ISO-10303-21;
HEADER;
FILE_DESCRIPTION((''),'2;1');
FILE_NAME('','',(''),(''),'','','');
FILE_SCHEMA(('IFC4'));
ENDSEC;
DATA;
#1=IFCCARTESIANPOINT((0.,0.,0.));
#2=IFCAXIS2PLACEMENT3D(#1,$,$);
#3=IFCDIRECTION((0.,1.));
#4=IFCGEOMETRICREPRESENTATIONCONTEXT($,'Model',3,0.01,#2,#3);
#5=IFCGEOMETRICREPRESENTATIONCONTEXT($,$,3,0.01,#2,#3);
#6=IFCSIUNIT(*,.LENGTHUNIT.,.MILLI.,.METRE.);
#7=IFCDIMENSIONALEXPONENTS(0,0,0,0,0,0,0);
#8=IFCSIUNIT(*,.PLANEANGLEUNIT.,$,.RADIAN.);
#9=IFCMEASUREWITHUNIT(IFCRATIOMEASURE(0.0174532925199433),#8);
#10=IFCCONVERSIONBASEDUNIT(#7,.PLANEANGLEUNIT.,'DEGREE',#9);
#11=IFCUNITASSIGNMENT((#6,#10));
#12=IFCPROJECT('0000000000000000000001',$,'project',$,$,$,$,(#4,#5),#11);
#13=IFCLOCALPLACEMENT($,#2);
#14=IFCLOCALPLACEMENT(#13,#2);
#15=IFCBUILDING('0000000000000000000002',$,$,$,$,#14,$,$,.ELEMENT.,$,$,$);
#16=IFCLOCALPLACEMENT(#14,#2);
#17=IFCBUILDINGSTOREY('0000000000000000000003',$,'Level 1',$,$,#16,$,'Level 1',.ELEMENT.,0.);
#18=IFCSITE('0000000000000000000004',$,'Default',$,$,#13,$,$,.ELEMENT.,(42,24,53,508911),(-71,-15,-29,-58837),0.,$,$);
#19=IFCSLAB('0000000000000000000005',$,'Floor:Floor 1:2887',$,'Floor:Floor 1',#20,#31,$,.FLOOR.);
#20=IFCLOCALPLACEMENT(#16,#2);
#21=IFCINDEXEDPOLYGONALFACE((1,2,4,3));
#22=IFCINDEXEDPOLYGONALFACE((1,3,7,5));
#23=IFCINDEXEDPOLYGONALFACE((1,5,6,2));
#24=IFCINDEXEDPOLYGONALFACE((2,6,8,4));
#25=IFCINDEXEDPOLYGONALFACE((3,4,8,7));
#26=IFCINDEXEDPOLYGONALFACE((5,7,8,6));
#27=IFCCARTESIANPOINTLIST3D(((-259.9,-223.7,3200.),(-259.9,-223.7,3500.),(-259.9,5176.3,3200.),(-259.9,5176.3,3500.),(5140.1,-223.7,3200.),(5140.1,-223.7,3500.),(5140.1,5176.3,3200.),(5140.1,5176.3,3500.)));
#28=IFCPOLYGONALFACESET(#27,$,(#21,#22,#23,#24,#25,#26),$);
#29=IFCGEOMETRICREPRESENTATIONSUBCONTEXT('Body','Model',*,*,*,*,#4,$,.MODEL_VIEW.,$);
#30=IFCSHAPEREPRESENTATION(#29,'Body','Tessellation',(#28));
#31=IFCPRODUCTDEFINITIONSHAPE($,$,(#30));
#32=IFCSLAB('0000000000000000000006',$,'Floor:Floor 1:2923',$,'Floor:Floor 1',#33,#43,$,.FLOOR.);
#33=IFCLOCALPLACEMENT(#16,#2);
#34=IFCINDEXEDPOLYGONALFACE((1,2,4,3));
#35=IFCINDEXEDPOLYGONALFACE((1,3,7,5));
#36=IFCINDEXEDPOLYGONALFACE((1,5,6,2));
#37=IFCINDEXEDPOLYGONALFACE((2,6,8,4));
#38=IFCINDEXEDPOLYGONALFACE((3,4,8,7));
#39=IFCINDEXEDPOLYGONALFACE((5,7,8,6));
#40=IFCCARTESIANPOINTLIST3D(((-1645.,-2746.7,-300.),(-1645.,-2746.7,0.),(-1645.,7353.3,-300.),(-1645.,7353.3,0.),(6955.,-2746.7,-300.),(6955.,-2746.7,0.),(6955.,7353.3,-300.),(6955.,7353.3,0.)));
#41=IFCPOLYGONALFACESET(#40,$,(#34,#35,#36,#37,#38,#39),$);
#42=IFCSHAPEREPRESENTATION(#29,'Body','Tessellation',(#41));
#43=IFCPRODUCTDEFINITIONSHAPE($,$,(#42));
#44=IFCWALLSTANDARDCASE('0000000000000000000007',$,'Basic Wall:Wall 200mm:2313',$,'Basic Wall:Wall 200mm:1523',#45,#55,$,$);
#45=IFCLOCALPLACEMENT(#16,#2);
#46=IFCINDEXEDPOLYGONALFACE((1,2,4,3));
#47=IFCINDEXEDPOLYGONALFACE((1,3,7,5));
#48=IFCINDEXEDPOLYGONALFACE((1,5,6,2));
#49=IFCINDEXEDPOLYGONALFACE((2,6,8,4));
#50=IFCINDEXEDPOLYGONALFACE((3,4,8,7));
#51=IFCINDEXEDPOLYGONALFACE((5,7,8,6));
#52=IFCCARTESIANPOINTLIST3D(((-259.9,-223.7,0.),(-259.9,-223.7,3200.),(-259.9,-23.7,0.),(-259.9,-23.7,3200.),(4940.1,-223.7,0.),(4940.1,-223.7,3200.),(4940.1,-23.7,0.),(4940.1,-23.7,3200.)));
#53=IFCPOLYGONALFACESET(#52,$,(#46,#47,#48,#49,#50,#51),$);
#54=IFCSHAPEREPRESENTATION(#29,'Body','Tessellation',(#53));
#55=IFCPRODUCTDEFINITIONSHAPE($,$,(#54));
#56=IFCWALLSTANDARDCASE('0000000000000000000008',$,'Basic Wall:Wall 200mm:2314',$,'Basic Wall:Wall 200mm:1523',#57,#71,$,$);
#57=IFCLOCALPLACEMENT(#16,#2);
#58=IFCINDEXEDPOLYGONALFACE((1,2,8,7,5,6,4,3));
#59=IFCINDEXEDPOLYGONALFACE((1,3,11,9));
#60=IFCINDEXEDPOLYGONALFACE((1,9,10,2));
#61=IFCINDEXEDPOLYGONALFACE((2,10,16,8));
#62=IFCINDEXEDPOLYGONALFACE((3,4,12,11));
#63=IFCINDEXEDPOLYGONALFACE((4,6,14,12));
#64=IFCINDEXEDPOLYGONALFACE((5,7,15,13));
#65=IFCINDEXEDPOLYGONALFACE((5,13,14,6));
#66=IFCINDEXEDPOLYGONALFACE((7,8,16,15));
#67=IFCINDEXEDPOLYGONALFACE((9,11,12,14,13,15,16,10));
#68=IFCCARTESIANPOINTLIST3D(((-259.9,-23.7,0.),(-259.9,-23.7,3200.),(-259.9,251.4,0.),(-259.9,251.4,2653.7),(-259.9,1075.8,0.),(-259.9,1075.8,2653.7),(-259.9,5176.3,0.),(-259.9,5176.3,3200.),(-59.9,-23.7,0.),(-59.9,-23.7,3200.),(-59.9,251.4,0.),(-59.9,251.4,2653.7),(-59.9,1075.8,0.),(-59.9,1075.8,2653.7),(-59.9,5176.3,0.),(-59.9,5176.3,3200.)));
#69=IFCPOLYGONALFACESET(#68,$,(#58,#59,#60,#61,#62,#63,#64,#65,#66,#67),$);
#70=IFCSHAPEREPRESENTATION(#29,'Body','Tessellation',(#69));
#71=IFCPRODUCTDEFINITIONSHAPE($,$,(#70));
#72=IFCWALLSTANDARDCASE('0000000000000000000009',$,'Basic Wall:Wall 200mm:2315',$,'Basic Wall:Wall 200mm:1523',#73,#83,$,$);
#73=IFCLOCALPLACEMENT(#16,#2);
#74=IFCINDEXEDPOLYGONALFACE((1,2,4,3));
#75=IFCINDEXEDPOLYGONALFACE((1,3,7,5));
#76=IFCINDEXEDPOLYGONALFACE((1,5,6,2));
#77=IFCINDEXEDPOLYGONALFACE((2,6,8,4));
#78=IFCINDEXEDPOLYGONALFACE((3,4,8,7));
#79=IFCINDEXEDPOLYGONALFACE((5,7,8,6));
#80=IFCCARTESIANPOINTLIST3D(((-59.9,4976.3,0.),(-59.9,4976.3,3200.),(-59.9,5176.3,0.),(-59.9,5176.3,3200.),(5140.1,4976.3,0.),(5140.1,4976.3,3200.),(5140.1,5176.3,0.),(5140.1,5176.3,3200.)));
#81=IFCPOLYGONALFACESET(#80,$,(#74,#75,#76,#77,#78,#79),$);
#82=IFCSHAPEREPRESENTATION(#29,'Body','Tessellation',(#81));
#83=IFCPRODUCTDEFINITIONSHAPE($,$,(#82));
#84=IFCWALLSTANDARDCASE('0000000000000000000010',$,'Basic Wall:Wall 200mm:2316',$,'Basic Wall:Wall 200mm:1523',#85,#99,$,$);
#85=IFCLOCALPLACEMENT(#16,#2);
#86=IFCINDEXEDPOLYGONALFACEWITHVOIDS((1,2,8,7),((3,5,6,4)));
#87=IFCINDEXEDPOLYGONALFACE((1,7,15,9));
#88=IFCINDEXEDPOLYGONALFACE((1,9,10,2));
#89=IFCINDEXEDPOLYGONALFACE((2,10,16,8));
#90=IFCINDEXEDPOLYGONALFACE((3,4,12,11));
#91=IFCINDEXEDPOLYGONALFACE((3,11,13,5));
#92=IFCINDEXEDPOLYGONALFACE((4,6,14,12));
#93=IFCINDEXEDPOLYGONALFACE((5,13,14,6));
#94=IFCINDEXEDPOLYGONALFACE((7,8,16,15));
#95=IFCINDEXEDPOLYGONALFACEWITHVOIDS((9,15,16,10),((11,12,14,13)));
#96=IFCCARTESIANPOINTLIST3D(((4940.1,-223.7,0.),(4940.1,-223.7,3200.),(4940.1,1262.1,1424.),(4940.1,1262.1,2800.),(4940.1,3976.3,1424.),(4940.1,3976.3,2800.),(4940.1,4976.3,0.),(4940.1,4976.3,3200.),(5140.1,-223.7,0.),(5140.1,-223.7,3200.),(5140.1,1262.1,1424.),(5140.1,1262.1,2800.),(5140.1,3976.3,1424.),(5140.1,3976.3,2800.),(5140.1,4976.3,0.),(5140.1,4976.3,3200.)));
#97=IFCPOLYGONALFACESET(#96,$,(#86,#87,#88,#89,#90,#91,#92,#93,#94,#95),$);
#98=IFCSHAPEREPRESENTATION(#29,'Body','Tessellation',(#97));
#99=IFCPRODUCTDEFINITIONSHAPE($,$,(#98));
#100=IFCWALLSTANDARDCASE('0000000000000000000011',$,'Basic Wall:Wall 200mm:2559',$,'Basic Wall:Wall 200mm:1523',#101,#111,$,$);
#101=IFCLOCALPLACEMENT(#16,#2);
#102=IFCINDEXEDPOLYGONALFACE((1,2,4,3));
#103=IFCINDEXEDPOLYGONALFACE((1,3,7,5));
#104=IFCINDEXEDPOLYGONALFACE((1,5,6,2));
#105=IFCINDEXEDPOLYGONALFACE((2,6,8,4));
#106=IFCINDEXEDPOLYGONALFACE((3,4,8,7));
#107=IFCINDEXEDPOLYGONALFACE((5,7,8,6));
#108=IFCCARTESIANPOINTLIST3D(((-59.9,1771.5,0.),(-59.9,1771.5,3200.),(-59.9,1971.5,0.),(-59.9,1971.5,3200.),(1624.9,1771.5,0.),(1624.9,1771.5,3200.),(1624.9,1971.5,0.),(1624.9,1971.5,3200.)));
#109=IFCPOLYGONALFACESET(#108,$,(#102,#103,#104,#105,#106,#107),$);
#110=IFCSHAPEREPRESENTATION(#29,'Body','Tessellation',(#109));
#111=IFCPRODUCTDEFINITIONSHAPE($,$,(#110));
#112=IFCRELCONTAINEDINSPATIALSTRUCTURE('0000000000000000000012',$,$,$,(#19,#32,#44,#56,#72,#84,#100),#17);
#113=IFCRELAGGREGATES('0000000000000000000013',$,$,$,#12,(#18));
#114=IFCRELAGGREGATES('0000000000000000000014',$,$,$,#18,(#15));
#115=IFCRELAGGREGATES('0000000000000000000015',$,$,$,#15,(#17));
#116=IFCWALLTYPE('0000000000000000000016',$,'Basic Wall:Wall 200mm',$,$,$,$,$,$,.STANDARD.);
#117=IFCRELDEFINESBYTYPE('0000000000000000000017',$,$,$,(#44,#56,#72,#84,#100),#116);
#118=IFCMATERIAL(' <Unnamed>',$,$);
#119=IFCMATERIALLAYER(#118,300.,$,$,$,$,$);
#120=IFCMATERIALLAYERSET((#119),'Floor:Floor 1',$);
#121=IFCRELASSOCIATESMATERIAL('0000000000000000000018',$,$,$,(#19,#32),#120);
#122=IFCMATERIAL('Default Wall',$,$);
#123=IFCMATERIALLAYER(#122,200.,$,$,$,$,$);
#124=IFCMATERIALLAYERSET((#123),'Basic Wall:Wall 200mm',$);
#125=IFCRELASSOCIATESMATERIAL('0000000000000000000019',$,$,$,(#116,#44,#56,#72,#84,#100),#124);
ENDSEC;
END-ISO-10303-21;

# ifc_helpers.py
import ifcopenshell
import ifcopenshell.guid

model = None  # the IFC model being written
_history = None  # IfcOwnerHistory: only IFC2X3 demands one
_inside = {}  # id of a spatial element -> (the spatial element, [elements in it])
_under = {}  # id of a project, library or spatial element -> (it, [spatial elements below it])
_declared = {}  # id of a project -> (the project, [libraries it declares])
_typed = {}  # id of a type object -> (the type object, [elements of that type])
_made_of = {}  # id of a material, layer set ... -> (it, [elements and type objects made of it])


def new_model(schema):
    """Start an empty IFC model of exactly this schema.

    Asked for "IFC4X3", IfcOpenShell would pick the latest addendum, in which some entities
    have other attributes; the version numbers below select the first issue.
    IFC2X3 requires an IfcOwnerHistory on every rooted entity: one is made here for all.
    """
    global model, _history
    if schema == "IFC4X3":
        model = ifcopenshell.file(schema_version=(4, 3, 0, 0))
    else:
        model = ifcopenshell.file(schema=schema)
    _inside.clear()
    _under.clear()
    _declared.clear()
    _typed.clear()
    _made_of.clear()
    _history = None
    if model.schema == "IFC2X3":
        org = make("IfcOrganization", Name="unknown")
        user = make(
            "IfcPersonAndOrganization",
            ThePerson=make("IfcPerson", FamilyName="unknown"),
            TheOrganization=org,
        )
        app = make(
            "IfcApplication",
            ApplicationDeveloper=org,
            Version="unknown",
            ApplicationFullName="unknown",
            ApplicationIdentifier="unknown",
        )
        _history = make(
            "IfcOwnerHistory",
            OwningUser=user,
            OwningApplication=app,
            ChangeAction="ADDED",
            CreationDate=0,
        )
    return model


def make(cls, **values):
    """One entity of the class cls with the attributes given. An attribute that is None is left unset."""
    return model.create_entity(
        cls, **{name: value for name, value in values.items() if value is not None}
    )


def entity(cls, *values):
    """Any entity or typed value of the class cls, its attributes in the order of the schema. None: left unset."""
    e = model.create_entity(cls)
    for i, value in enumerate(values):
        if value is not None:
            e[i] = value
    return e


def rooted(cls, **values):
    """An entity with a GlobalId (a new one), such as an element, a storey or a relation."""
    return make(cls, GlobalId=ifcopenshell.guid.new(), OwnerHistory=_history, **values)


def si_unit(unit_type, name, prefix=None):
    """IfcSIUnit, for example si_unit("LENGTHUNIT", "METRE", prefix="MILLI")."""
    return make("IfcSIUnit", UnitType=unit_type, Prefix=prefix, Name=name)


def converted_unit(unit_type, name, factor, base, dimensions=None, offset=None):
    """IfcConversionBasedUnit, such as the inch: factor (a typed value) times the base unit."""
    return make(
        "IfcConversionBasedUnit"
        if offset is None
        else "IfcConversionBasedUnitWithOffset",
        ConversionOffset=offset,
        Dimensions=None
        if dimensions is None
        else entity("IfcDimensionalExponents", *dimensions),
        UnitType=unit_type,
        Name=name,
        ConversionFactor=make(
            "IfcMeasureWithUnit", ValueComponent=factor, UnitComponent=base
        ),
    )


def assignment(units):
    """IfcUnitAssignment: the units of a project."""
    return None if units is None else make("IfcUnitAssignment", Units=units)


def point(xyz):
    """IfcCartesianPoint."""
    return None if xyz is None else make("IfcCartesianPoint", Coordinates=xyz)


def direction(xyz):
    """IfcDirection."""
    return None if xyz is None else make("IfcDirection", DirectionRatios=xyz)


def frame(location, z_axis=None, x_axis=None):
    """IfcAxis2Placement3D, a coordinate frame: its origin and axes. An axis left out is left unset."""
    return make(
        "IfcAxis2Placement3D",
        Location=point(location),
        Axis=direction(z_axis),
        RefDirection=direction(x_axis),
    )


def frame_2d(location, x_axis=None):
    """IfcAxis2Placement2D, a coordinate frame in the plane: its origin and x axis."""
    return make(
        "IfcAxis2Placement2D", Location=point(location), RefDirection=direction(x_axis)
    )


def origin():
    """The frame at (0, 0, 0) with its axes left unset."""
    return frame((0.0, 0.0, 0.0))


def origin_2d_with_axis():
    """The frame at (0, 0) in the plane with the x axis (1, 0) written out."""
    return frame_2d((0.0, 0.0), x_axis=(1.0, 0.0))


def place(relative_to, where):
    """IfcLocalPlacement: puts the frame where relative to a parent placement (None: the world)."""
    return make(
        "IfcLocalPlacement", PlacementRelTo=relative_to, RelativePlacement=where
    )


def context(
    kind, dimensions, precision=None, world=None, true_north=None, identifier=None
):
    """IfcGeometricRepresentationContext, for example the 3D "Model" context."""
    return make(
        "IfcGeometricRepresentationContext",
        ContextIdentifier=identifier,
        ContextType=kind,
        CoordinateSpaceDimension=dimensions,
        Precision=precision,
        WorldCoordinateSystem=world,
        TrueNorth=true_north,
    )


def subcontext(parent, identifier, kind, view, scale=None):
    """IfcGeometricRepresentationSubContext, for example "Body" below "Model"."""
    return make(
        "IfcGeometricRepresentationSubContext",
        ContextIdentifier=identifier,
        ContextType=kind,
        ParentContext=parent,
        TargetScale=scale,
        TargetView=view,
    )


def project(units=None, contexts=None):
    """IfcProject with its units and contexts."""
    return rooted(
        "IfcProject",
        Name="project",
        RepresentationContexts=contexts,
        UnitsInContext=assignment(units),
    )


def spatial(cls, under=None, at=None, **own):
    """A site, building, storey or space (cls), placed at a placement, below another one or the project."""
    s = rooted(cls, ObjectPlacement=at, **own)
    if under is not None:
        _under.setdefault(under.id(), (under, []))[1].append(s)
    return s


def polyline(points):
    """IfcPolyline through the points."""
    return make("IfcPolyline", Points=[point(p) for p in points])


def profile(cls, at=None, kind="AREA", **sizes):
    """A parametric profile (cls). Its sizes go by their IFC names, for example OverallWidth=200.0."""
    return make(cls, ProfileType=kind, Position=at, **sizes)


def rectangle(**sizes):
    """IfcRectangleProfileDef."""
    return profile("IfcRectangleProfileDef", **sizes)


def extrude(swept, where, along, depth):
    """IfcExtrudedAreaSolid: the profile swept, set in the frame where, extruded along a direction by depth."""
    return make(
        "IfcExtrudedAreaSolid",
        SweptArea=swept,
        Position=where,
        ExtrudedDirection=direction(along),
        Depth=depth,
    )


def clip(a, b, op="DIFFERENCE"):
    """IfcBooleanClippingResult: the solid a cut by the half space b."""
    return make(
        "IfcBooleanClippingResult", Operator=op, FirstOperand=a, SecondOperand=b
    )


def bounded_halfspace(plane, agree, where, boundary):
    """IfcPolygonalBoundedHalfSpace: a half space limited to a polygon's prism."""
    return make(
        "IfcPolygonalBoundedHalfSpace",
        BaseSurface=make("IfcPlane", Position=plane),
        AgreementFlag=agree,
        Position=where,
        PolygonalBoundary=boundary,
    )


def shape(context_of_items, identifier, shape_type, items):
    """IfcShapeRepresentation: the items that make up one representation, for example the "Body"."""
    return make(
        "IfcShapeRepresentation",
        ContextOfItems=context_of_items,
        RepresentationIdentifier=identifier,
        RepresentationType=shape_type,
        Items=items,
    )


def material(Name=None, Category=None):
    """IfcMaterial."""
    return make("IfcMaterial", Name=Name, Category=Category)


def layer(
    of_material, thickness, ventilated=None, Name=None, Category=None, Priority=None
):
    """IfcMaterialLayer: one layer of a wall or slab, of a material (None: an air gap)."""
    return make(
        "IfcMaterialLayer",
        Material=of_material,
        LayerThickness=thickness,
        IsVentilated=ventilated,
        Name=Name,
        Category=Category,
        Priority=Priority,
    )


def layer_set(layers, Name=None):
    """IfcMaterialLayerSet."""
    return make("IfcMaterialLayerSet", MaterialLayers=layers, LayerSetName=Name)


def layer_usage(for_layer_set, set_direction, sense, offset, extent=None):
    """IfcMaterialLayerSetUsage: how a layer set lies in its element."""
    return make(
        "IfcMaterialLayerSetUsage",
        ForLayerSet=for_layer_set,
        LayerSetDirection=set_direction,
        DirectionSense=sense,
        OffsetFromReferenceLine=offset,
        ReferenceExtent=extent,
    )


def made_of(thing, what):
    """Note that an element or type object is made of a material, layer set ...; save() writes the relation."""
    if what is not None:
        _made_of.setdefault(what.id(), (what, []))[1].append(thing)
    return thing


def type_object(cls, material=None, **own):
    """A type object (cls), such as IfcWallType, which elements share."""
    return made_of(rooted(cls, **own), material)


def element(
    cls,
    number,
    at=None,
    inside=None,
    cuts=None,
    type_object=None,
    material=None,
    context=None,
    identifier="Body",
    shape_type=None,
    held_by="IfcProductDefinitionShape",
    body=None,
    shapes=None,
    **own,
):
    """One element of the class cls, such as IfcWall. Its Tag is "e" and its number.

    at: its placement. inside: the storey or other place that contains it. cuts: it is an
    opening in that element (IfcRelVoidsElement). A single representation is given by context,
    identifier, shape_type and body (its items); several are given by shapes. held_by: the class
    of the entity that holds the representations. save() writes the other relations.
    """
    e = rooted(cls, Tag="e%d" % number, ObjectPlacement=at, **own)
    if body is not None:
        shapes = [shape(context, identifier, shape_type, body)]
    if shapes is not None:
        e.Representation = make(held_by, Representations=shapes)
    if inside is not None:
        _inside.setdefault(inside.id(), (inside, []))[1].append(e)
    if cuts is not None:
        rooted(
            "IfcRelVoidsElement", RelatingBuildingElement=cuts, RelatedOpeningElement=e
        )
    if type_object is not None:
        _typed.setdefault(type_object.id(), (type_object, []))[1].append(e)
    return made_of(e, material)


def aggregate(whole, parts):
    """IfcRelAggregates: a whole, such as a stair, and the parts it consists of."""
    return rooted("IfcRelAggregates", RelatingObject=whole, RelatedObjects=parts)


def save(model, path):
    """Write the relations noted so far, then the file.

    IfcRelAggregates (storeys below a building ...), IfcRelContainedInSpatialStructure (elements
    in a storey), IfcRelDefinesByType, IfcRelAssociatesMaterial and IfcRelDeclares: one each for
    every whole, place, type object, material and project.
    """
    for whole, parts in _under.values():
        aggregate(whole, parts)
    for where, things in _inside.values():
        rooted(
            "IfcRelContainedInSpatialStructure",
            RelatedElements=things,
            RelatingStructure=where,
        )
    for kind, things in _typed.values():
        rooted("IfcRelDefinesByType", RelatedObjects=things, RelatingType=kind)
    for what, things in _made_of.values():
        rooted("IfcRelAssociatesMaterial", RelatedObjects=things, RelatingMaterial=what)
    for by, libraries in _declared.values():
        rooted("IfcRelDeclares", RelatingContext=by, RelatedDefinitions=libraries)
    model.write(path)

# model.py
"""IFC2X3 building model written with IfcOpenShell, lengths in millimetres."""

from ifc_helpers import new_model, entity, si_unit, converted_unit, direction, frame, frame_2d, origin, origin_2d_with_axis, place, context, subcontext, project, spatial, polyline, rectangle, extrude, clip, bounded_halfspace, material, layer, layer_set, layer_usage, type_object, element, save


model = new_model("IFC2X3")

# Units and contexts
model_context = context("Model", 3, precision=0.01, world=origin(), true_north=direction((0.0, 1.0)))
context_of_model = context(None, 3, precision=0.01, world=origin(), true_north=direction((0.0, 1.0)))
body_context = subcontext(model_context, "Body", "Model", "MODEL_VIEW")
ifc_project = project(units=[si_unit("LENGTHUNIT", "METRE", prefix="MILLI"), converted_unit("PLANEANGLEUNIT", "DEGREE", entity("IfcRatioMeasure", 0.0174532925199433), si_unit("PLANEANGLEUNIT", "RADIAN"), dimensions=[0, 0, 0, 0, 0, 0, 0])], contexts=[model_context, context_of_model])

# Site, building, storey
site_placement = place(None, origin())
site = spatial("IfcSite", under=ifc_project, at=site_placement, Name="Default", CompositionType="ELEMENT", RefLatitude=(42, 24, 53, 508911), RefLongitude=(-71, -15, -29, -58837), RefElevation=0.0)
building_placement = place(site_placement, origin())
building = spatial("IfcBuilding", under=site, at=building_placement, CompositionType="ELEMENT")
storey_placement = place(building_placement, origin())
storey = spatial("IfcBuildingStorey", under=building, at=storey_placement, Name="Level 1", LongName="Level 1", CompositionType="ELEMENT", Elevation=0.0)

# Slabs
ifc_material_1 = material(Name=" <Unnamed>")
ifc_layer_1 = layer(ifc_material_1, 300.0)
ifc_layer_set_1 = layer_set([ifc_layer_1], Name="Floor:Floor 1")
ifc_layer_usage_1 = layer_usage(ifc_layer_set_1, "AXIS3", "POSITIVE", 0.0)
slab_1_placement = place(storey_placement, origin())
element("IfcSlab", 1, at=slab_1_placement, inside=storey, material=ifc_layer_usage_1, Name="Floor:Floor 1:2887", ObjectType="Floor:Floor 1", PredefinedType="FLOOR", context=body_context, shape_type="SweptSolid", body=[
    extrude(rectangle(XDim=5400.0, YDim=5400.0, at=origin_2d_with_axis()), frame((2440.1, 2476.3, 3500.0), z_axis=(0.0, 0.0, -1.0), x_axis=(0.0, 1.0, 0.0)), (0.0, 0.0, 1.0), 300.0),
])
ifc_layer_usage_2 = layer_usage(ifc_layer_set_1, "AXIS3", "POSITIVE", 0.0)
slab_2_placement = place(storey_placement, origin())
element("IfcSlab", 2, at=slab_2_placement, inside=storey, material=ifc_layer_usage_2, Name="Floor:Floor 1:2923", ObjectType="Floor:Floor 1", PredefinedType="FLOOR", context=body_context, shape_type="SweptSolid", body=[
    extrude(rectangle(XDim=10100.0, YDim=8600.0, at=origin_2d_with_axis()), frame((2655.0, 2303.3, 0.0), z_axis=(0.0, 0.0, -1.0), x_axis=(0.0, 1.0, 0.0)), (0.0, 0.0, 1.0), 300.0),
])

# Wall
ifc_material_2 = material(Name="Default Wall")
ifc_layer_2 = layer(ifc_material_2, 200.0)
ifc_layer_set_2 = layer_set([ifc_layer_2], Name="Basic Wall:Wall 200mm")
ifc_layer_usage_3 = layer_usage(ifc_layer_set_2, "AXIS2", "NEGATIVE", 100.0)
wall_type = type_object("IfcWallType", Name="Basic Wall:Wall 200mm", PredefinedType="STANDARD", material=ifc_layer_set_2)
wall_1_placement = place(storey_placement, frame((-259.9, -123.7, 0.0)))
element("IfcWallStandardCase", 3, at=wall_1_placement, inside=storey, type_object=wall_type, material=ifc_layer_usage_3, Name="Basic Wall:Wall 200mm:2313", ObjectType="Basic Wall:Wall 200mm:1523", context=body_context, shape_type="Clipping", body=[
    clip(extrude(rectangle(XDim=5200.0, YDim=200.0, at=frame_2d((2600.0, 0.0), x_axis=(-1.0, 0.0))), origin(), (0.0, 0.0, 1.0), 3200.0), bounded_halfspace(frame((0.0, -100.0, 3200.0), z_axis=(0.0, 0.0, -1.0), x_axis=(1.0, 0.0, 0.0)), True, frame((0.0, -100.0, 3200.0)), polyline([(0.0, 0.0), (5200.0, 0.0), (5200.0, 200.0), (2084.8, 200.0), (1884.8, 200.0), (200.0, 200.0), (0.0, 200.0), (0.0, 0.0)]))),
])

# Wall, opening
ifc_layer_usage_4 = layer_usage(ifc_layer_set_2, "AXIS2", "NEGATIVE", 100.0)
wall_2_placement = place(storey_placement, frame((-159.9, 5176.3, 0.0), z_axis=(0.0, 0.0, 1.0), x_axis=(0.0, -1.0, 0.0)))
wall_2 = element("IfcWallStandardCase", 4, at=wall_2_placement, inside=storey, type_object=wall_type, material=ifc_layer_usage_4, Name="Basic Wall:Wall 200mm:2314", ObjectType="Basic Wall:Wall 200mm:1523", context=body_context, shape_type="Clipping", body=[
    clip(extrude(rectangle(XDim=5200.0, YDim=200.0, at=frame_2d((2600.0, 0.0), x_axis=(-1.0, 0.0))), origin(), (0.0, 0.0, 1.0), 3200.0), bounded_halfspace(frame((0.0, -100.0, 3200.0), z_axis=(0.0, 0.0, -1.0), x_axis=(0.0, 1.0, 0.0)), True, frame((0.0, -100.0, 3200.0)), polyline([(0.0, 0.0), (5200.0, 0.0), (5200.0, 200.0), (3404.8, 200.0), (3204.8, 200.0), (200.0, 200.0), (0.0, 200.0), (0.0, 0.0)]))),
])
opening_1_placement = place(wall_2_placement, origin())
element("IfcOpeningElement", 5, at=opening_1_placement, cuts=wall_2, ObjectType="Opening", context=body_context, shape_type="SweptSolid", body=[
    extrude(rectangle(XDim=2688.4, YDim=824.4, at=frame_2d((0.0, 0.0), x_axis=(1.0, 0.0))), frame((4512.7, -100.0, 1309.5), z_axis=(0.0, 1.0, 0.0), x_axis=(0.0, 0.0, -1.0)), (0.0, 0.0, 1.0), 200.0),
])

# Wall
ifc_layer_usage_5 = layer_usage(ifc_layer_set_2, "AXIS2", "NEGATIVE", 100.0)
wall_3_placement = place(storey_placement, frame((5140.1, 5076.3, 0.0), z_axis=(0.0, 0.0, 1.0), x_axis=(-1.0, 0.0, 0.0)))
element("IfcWallStandardCase", 6, at=wall_3_placement, inside=storey, type_object=wall_type, material=ifc_layer_usage_5, Name="Basic Wall:Wall 200mm:2315", ObjectType="Basic Wall:Wall 200mm:1523", context=body_context, shape_type="Clipping", body=[
    clip(extrude(rectangle(XDim=5200.0, YDim=200.0, at=frame_2d((2600.0, 0.0), x_axis=(-1.0, 0.0))), origin(), (0.0, 0.0, 1.0), 3200.0), bounded_halfspace(frame((0.0, -100.0, 3200.0), z_axis=(0.0, 0.0, -1.0), x_axis=(-1.0, 0.0, 0.0)), True, frame((0.0, -100.0, 3200.0)), polyline([(0.0, 0.0), (5200.0, 0.0), (5200.0, 200.0), (3515.2, 200.0), (3315.2, 200.0), (200.0, 200.0), (0.0, 200.0), (0.0, 0.0)]))),
])

# Wall, opening
ifc_layer_usage_6 = layer_usage(ifc_layer_set_2, "AXIS2", "NEGATIVE", 100.0)
wall_4_placement = place(storey_placement, frame((5040.1, -223.7, 0.0), z_axis=(0.0, 0.0, 1.0), x_axis=(0.0, 1.0, 0.0)))
wall_4 = element("IfcWallStandardCase", 7, at=wall_4_placement, inside=storey, type_object=wall_type, material=ifc_layer_usage_6, Name="Basic Wall:Wall 200mm:2316", ObjectType="Basic Wall:Wall 200mm:1523", context=body_context, shape_type="Clipping", body=[
    clip(extrude(rectangle(XDim=5200.0, YDim=200.0, at=frame_2d((2600.0, 0.0), x_axis=(-1.0, 0.0))), origin(), (0.0, 0.0, 1.0), 3200.0), bounded_halfspace(frame((0.0, -100.0, 3200.0), z_axis=(0.0, 0.0, -1.0), x_axis=(0.0, -1.0, 0.0)), True, frame((0.0, -100.0, 3200.0)), polyline([(0.0, 0.0), (5200.0, 0.0), (5200.0, 200.0), (200.0, 200.0), (0.0, 200.0), (0.0, 0.0)]))),
])
opening_2_placement = place(wall_4_placement, origin())
element("IfcOpeningElement", 8, at=opening_2_placement, cuts=wall_4, ObjectType="Opening", context=body_context, shape_type="SweptSolid", body=[
    extrude(rectangle(XDim=1376.0, YDim=2714.2, at=origin_2d_with_axis()), frame((2842.9, -100.0, 2112.0), z_axis=(0.0, 1.0, 0.0), x_axis=(0.0, 0.0, -1.0)), (0.0, 0.0, 1.0), 200.0),
])

# Wall
ifc_layer_usage_7 = layer_usage(ifc_layer_set_2, "AXIS2", "NEGATIVE", 100.0)
wall_5_placement = place(storey_placement, frame((1624.9, 1871.5, 0.0), z_axis=(0.0, 0.0, 1.0), x_axis=(-1.0, 0.0, 0.0)))
element("IfcWallStandardCase", 9, at=wall_5_placement, inside=storey, type_object=wall_type, material=ifc_layer_usage_7, Name="Basic Wall:Wall 200mm:2559", ObjectType="Basic Wall:Wall 200mm:1523", context=body_context, shape_type="Clipping", body=[
    clip(extrude(rectangle(XDim=1684.8, YDim=200.0, at=frame_2d((842.4, 0.0), x_axis=(-1.0, 0.0))), origin(), (0.0, 0.0, 1.0), 3200.0), bounded_halfspace(frame((0.0, -100.0, 3200.0), z_axis=(0.0, 0.0, -1.0), x_axis=(-1.0, 0.0, 0.0)), True, frame((0.0, -100.0, 3200.0)), polyline([(0.0, 0.0), (1684.8, 0.0), (1684.8, 200.0), (0.0, 200.0), (0.0, 0.0)]))),
])

save(model, "model.ifc")
